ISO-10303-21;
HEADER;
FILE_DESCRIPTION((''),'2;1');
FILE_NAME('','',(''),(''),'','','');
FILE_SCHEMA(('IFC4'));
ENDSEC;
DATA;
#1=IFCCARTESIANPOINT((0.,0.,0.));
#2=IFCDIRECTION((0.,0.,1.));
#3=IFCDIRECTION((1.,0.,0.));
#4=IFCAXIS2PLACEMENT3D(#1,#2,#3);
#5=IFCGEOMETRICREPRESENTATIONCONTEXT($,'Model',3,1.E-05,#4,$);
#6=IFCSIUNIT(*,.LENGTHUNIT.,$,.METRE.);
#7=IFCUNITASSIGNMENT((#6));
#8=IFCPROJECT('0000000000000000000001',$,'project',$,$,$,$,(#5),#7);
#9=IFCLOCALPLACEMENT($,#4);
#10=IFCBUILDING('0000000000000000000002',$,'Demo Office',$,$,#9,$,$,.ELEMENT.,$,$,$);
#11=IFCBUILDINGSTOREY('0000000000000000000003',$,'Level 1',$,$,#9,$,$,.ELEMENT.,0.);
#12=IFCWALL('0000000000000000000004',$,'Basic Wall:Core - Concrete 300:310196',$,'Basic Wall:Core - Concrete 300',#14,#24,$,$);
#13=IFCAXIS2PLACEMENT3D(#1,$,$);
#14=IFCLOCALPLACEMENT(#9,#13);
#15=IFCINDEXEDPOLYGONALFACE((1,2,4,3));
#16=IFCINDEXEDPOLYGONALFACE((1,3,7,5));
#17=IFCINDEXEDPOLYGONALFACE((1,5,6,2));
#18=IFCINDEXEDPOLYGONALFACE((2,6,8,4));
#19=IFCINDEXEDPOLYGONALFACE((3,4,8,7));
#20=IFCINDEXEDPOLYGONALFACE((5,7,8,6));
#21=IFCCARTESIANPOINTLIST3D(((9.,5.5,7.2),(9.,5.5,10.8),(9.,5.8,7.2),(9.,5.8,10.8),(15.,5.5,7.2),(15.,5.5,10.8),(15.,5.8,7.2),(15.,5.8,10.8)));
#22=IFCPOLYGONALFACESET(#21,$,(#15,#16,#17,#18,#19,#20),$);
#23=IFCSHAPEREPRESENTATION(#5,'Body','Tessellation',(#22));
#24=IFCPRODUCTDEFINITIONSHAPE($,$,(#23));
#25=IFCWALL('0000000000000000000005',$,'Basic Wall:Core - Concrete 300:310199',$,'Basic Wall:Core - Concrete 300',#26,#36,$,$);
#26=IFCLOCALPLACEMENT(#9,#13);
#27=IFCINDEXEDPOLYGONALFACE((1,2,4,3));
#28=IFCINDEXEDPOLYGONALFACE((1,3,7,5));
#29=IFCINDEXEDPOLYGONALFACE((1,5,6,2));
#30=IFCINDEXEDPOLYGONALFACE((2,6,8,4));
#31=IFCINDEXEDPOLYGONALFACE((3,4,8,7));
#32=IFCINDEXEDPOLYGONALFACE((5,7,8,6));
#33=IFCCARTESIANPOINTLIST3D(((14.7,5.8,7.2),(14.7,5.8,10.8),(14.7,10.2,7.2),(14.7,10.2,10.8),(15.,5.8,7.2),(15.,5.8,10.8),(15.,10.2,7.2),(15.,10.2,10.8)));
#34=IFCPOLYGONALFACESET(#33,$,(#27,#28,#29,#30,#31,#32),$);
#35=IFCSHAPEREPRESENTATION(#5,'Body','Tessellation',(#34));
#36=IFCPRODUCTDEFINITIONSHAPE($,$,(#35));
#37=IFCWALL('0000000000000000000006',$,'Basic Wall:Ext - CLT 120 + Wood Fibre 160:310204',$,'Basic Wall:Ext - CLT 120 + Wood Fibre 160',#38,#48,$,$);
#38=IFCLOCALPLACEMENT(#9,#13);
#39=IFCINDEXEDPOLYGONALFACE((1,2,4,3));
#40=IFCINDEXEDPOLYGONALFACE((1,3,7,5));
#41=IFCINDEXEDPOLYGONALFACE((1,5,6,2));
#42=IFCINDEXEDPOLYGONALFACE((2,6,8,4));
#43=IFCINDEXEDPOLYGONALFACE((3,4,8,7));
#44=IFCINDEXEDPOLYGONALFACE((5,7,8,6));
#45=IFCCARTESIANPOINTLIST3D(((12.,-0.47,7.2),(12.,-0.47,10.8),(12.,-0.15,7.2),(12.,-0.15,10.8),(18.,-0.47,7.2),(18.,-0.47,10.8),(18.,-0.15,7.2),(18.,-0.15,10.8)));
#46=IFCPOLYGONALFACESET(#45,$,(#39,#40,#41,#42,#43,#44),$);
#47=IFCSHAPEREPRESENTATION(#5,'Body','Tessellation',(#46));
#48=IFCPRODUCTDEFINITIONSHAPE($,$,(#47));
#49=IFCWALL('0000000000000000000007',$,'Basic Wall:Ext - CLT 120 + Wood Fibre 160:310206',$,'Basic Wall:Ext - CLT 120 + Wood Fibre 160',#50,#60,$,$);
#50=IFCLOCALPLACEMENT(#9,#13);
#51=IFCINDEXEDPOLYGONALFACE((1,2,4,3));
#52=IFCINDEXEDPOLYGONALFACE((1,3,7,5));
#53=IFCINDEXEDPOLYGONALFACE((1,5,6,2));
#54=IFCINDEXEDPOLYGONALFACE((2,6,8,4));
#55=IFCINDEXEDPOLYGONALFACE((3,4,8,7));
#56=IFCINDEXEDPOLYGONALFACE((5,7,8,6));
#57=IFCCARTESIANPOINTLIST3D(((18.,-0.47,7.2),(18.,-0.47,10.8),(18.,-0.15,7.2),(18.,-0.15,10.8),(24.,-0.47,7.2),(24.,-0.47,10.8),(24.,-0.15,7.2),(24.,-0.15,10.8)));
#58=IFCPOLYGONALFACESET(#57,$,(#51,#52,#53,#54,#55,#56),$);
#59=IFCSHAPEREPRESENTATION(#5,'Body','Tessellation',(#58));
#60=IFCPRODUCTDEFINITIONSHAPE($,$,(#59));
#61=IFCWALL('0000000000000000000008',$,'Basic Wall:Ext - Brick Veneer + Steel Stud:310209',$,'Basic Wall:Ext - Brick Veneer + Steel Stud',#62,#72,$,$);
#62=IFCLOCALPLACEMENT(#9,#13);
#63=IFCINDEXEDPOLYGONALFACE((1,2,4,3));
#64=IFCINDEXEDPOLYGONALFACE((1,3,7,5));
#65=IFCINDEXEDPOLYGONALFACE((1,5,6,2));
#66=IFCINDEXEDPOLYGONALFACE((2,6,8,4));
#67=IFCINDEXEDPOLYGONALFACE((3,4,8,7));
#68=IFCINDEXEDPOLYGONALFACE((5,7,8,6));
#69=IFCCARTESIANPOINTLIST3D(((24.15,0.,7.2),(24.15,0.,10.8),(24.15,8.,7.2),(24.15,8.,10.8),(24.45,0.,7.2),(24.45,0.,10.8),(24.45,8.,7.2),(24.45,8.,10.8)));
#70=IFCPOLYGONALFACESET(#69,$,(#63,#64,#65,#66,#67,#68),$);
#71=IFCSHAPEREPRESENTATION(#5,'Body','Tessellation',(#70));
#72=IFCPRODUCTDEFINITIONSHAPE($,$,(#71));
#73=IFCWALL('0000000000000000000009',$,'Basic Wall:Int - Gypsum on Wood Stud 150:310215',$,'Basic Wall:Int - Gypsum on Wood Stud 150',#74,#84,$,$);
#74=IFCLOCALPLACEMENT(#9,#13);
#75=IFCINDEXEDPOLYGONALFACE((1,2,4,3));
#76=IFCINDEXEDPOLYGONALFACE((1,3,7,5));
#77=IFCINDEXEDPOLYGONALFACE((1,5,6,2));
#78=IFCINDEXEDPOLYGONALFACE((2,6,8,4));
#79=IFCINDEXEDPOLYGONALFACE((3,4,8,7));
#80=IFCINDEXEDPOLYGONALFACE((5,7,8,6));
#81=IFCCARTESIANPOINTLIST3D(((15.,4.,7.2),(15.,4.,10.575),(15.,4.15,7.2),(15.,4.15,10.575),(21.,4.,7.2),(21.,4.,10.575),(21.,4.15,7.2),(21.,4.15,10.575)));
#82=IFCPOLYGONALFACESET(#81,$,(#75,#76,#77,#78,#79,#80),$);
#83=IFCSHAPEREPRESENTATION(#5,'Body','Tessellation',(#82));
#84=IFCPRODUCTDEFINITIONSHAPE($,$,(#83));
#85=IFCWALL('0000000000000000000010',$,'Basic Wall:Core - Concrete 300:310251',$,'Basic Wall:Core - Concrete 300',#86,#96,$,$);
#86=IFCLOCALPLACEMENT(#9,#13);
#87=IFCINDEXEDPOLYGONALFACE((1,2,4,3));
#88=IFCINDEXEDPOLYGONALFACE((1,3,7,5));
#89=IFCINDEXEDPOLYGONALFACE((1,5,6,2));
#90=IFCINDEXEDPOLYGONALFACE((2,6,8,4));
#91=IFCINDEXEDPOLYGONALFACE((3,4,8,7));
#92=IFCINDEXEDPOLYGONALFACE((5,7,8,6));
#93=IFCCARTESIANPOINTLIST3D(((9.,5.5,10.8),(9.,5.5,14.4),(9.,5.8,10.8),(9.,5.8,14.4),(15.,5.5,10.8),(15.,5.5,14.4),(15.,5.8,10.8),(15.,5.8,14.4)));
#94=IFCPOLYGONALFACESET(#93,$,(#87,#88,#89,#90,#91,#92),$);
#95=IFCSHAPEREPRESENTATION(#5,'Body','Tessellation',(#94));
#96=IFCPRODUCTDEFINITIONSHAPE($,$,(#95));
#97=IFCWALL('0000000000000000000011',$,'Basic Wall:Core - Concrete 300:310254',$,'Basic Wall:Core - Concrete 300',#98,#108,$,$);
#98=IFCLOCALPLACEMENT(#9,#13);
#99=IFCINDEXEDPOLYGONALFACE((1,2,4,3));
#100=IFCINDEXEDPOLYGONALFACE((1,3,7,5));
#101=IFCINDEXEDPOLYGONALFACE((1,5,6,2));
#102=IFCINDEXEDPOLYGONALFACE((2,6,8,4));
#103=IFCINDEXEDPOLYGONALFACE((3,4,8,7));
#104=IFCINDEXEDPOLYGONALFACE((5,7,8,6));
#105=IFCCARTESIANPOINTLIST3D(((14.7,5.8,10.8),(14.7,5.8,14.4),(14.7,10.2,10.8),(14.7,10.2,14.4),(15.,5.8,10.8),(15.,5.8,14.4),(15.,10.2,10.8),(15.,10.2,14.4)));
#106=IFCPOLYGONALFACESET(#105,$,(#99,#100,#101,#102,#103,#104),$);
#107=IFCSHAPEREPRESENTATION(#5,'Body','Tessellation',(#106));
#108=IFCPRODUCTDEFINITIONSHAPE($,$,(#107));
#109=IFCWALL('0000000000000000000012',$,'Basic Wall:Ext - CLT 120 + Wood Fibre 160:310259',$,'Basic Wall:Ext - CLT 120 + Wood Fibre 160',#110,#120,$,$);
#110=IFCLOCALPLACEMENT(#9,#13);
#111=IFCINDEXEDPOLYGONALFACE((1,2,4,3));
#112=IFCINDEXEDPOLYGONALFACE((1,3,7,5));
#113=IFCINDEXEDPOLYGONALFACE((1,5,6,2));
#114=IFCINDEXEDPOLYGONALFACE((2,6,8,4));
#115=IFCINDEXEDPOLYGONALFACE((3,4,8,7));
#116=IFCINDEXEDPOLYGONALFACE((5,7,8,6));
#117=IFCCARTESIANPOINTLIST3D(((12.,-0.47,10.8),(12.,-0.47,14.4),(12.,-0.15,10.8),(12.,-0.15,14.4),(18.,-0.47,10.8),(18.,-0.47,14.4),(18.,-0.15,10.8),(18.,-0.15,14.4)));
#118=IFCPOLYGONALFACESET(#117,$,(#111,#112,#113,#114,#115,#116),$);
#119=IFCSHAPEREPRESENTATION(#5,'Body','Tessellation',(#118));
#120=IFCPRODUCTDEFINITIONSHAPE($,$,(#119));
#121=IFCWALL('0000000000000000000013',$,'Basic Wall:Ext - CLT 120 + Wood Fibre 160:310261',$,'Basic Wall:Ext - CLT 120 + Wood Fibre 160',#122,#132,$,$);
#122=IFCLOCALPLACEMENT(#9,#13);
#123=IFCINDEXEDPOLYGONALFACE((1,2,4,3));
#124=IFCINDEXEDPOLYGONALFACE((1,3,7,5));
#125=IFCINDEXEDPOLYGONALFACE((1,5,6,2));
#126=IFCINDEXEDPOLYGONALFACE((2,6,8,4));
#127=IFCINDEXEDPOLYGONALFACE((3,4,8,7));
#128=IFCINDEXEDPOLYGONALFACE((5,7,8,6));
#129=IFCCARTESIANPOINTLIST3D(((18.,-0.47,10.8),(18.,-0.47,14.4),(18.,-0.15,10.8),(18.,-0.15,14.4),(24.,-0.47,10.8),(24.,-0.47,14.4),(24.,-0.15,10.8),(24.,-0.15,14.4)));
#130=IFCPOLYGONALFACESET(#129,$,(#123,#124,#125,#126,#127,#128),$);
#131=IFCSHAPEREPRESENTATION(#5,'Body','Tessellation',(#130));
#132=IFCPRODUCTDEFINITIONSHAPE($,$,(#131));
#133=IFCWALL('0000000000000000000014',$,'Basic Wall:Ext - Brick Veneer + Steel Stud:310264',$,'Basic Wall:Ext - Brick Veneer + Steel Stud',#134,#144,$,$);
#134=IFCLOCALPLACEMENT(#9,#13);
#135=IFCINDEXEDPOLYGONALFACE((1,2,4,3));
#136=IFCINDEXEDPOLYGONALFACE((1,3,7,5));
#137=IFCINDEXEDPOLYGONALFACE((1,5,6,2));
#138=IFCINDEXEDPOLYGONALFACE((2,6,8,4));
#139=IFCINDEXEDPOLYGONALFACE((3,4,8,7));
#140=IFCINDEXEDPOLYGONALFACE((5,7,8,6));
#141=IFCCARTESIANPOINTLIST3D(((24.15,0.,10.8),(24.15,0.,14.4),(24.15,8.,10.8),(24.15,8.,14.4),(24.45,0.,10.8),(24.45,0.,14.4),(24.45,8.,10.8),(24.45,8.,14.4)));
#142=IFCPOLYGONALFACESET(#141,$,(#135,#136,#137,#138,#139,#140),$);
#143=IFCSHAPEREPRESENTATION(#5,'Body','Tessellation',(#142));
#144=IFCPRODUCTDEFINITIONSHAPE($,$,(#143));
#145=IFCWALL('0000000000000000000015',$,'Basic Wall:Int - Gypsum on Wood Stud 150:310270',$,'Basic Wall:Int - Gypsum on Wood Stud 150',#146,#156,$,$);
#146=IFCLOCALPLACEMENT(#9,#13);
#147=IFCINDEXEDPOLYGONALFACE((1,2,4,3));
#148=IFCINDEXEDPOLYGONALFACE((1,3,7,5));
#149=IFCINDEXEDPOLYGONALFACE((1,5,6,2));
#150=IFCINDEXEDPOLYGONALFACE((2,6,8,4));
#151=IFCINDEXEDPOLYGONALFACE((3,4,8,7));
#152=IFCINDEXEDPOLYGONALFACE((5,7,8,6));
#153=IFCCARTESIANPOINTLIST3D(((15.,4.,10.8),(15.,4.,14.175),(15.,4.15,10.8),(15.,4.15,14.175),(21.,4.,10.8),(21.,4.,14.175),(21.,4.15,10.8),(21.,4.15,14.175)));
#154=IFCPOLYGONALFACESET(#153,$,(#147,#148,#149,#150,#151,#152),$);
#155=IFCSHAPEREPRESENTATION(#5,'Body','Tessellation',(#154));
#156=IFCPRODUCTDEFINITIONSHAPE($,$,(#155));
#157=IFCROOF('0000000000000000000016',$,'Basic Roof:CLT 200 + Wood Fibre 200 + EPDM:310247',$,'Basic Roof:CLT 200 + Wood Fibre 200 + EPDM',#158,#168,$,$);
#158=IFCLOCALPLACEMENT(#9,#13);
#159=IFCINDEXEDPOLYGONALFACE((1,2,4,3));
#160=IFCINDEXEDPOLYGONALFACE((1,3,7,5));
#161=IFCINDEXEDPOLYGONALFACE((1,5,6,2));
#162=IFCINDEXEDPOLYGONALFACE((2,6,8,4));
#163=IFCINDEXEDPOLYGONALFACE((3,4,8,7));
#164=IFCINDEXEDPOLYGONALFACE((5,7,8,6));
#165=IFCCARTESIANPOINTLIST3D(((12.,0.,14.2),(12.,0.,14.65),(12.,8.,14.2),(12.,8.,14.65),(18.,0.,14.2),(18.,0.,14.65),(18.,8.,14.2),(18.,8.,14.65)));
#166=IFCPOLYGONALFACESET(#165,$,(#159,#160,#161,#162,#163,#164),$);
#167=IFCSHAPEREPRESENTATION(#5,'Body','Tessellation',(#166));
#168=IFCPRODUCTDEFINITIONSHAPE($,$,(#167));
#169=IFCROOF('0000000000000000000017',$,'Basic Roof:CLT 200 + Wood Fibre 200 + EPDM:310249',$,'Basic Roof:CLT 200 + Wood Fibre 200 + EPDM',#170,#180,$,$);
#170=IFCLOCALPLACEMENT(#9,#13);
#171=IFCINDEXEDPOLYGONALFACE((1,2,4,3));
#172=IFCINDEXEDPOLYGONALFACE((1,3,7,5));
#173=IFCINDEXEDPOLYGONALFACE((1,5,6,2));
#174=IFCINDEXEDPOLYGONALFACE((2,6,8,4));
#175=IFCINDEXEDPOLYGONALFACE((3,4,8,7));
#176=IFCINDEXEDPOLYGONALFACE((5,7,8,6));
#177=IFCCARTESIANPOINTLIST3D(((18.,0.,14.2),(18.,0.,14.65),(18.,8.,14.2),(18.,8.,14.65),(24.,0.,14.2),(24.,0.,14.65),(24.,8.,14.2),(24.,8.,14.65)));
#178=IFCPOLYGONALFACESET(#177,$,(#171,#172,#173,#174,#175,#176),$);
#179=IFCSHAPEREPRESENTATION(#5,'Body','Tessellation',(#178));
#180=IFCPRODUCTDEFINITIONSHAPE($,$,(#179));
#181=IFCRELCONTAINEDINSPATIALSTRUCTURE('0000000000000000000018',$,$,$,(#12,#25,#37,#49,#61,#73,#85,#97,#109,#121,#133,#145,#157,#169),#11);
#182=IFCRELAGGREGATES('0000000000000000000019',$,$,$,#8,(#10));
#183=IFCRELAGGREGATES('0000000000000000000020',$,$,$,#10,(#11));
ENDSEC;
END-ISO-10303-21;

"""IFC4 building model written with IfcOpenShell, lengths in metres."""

from ifc_helpers import new_model, si_unit, frame, origin_with_axes, origin_2d, place, context, project, spatial, rectangle, extrude, element, save


model = new_model("IFC4")

# Units and contexts
model_context = context("Model", 3, precision=1e-05, world=origin_with_axes())
ifc_project = project(units=[si_unit("LENGTHUNIT", "METRE")], contexts=[model_context])

# Building, storey
placement = place(None, origin_with_axes())
building = spatial("IfcBuilding", under=ifc_project, at=placement, Name="Demo Office", CompositionType="ELEMENT")
storey = spatial("IfcBuildingStorey", under=building, at=placement, Name="Level 1", CompositionType="ELEMENT", Elevation=0.0)

# Walls
wall_1_placement = place(placement, frame((12.0, 5.65, 7.2)))
element("IfcWall", 1, at=wall_1_placement, inside=storey, Name="Basic Wall:Core - Concrete 300:310196", ObjectType="Basic Wall:Core - Concrete 300", context=model_context, shape_type="SweptSolid", body=[
    extrude(rectangle(XDim=6.0, YDim=0.3, at=origin_2d()), origin_with_axes(), (0.0, 0.0, 1.0), 3.6),
])
wall_2_placement = place(placement, frame((14.85, 8.0, 7.2)))
element("IfcWall", 2, at=wall_2_placement, inside=storey, Name="Basic Wall:Core - Concrete 300:310199", ObjectType="Basic Wall:Core - Concrete 300", context=model_context, shape_type="SweptSolid", body=[
    extrude(rectangle(XDim=0.3, YDim=4.4, at=origin_2d()), origin_with_axes(), (0.0, 0.0, 1.0), 3.6),
])
for number, where, name in (
    (3, (15.0, -0.31, 7.2), "Basic Wall:Ext - CLT 120 + Wood Fibre 160:310204"),
    (4, (21.0, -0.31, 7.2), "Basic Wall:Ext - CLT 120 + Wood Fibre 160:310206"),
):
    element("IfcWall", number, at=place(placement, frame(where)), inside=storey, Name=name, ObjectType="Basic Wall:Ext - CLT 120 + Wood Fibre 160", context=model_context, shape_type="SweptSolid", body=[
        extrude(rectangle(XDim=6.0, YDim=0.32, at=origin_2d()), origin_with_axes(), (0.0, 0.0, 1.0), 3.6),
    ])
wall_3_placement = place(placement, frame((24.3, 4.0, 7.2)))
element("IfcWall", 5, at=wall_3_placement, inside=storey, Name="Basic Wall:Ext - Brick Veneer + Steel Stud:310209", ObjectType="Basic Wall:Ext - Brick Veneer + Steel Stud", context=model_context, shape_type="SweptSolid", body=[
    extrude(rectangle(XDim=0.3, YDim=8.0, at=origin_2d()), origin_with_axes(), (0.0, 0.0, 1.0), 3.6),
])
wall_4_placement = place(placement, frame((18.0, 4.075, 7.2)))
element("IfcWall", 6, at=wall_4_placement, inside=storey, Name="Basic Wall:Int - Gypsum on Wood Stud 150:310215", ObjectType="Basic Wall:Int - Gypsum on Wood Stud 150", context=model_context, shape_type="SweptSolid", body=[
    extrude(rectangle(XDim=6.0, YDim=0.15, at=origin_2d()), origin_with_axes(), (0.0, 0.0, 1.0), 3.375),
])
wall_5_placement = place(placement, frame((12.0, 5.65, 10.8)))
element("IfcWall", 7, at=wall_5_placement, inside=storey, Name="Basic Wall:Core - Concrete 300:310251", ObjectType="Basic Wall:Core - Concrete 300", context=model_context, shape_type="SweptSolid", body=[
    extrude(rectangle(XDim=6.0, YDim=0.3, at=origin_2d()), origin_with_axes(), (0.0, 0.0, 1.0), 3.6),
])
wall_6_placement = place(placement, frame((14.85, 8.0, 10.8)))
element("IfcWall", 8, at=wall_6_placement, inside=storey, Name="Basic Wall:Core - Concrete 300:310254", ObjectType="Basic Wall:Core - Concrete 300", context=model_context, shape_type="SweptSolid", body=[
    extrude(rectangle(XDim=0.3, YDim=4.4, at=origin_2d()), origin_with_axes(), (0.0, 0.0, 1.0), 3.6),
])
for number, where, name in (
    (9, (15.0, -0.31, 10.8), "Basic Wall:Ext - CLT 120 + Wood Fibre 160:310259"),
    (10, (21.0, -0.31, 10.8), "Basic Wall:Ext - CLT 120 + Wood Fibre 160:310261"),
):
    element("IfcWall", number, at=place(placement, frame(where)), inside=storey, Name=name, ObjectType="Basic Wall:Ext - CLT 120 + Wood Fibre 160", context=model_context, shape_type="SweptSolid", body=[
        extrude(rectangle(XDim=6.0, YDim=0.32, at=origin_2d()), origin_with_axes(), (0.0, 0.0, 1.0), 3.6),
    ])
wall_7_placement = place(placement, frame((24.3, 4.0, 10.8)))
element("IfcWall", 11, at=wall_7_placement, inside=storey, Name="Basic Wall:Ext - Brick Veneer + Steel Stud:310264", ObjectType="Basic Wall:Ext - Brick Veneer + Steel Stud", context=model_context, shape_type="SweptSolid", body=[
    extrude(rectangle(XDim=0.3, YDim=8.0, at=origin_2d()), origin_with_axes(), (0.0, 0.0, 1.0), 3.6),
])
wall_8_placement = place(placement, frame((18.0, 4.075, 10.8)))
element("IfcWall", 12, at=wall_8_placement, inside=storey, Name="Basic Wall:Int - Gypsum on Wood Stud 150:310270", ObjectType="Basic Wall:Int - Gypsum on Wood Stud 150", context=model_context, shape_type="SweptSolid", body=[
    extrude(rectangle(XDim=6.0, YDim=0.15, at=origin_2d()), origin_with_axes(), (0.0, 0.0, 1.0), 3.375),
])

# Roofs
for number, where, name in (
    (13, (15.0, 4.0, 14.2), "Basic Roof:CLT 200 + Wood Fibre 200 + EPDM:310247"),
    (14, (21.0, 4.0, 14.2), "Basic Roof:CLT 200 + Wood Fibre 200 + EPDM:310249"),
):
    element("IfcRoof", number, at=place(placement, frame(where)), inside=storey, Name=name, ObjectType="Basic Roof:CLT 200 + Wood Fibre 200 + EPDM", context=model_context, shape_type="SweptSolid", body=[
        extrude(rectangle(XDim=6.0, YDim=8.0, at=origin_2d()), origin_with_axes(), (0.0, 0.0, 1.0), 0.45),
    ])

save(model, "model.ifc")
